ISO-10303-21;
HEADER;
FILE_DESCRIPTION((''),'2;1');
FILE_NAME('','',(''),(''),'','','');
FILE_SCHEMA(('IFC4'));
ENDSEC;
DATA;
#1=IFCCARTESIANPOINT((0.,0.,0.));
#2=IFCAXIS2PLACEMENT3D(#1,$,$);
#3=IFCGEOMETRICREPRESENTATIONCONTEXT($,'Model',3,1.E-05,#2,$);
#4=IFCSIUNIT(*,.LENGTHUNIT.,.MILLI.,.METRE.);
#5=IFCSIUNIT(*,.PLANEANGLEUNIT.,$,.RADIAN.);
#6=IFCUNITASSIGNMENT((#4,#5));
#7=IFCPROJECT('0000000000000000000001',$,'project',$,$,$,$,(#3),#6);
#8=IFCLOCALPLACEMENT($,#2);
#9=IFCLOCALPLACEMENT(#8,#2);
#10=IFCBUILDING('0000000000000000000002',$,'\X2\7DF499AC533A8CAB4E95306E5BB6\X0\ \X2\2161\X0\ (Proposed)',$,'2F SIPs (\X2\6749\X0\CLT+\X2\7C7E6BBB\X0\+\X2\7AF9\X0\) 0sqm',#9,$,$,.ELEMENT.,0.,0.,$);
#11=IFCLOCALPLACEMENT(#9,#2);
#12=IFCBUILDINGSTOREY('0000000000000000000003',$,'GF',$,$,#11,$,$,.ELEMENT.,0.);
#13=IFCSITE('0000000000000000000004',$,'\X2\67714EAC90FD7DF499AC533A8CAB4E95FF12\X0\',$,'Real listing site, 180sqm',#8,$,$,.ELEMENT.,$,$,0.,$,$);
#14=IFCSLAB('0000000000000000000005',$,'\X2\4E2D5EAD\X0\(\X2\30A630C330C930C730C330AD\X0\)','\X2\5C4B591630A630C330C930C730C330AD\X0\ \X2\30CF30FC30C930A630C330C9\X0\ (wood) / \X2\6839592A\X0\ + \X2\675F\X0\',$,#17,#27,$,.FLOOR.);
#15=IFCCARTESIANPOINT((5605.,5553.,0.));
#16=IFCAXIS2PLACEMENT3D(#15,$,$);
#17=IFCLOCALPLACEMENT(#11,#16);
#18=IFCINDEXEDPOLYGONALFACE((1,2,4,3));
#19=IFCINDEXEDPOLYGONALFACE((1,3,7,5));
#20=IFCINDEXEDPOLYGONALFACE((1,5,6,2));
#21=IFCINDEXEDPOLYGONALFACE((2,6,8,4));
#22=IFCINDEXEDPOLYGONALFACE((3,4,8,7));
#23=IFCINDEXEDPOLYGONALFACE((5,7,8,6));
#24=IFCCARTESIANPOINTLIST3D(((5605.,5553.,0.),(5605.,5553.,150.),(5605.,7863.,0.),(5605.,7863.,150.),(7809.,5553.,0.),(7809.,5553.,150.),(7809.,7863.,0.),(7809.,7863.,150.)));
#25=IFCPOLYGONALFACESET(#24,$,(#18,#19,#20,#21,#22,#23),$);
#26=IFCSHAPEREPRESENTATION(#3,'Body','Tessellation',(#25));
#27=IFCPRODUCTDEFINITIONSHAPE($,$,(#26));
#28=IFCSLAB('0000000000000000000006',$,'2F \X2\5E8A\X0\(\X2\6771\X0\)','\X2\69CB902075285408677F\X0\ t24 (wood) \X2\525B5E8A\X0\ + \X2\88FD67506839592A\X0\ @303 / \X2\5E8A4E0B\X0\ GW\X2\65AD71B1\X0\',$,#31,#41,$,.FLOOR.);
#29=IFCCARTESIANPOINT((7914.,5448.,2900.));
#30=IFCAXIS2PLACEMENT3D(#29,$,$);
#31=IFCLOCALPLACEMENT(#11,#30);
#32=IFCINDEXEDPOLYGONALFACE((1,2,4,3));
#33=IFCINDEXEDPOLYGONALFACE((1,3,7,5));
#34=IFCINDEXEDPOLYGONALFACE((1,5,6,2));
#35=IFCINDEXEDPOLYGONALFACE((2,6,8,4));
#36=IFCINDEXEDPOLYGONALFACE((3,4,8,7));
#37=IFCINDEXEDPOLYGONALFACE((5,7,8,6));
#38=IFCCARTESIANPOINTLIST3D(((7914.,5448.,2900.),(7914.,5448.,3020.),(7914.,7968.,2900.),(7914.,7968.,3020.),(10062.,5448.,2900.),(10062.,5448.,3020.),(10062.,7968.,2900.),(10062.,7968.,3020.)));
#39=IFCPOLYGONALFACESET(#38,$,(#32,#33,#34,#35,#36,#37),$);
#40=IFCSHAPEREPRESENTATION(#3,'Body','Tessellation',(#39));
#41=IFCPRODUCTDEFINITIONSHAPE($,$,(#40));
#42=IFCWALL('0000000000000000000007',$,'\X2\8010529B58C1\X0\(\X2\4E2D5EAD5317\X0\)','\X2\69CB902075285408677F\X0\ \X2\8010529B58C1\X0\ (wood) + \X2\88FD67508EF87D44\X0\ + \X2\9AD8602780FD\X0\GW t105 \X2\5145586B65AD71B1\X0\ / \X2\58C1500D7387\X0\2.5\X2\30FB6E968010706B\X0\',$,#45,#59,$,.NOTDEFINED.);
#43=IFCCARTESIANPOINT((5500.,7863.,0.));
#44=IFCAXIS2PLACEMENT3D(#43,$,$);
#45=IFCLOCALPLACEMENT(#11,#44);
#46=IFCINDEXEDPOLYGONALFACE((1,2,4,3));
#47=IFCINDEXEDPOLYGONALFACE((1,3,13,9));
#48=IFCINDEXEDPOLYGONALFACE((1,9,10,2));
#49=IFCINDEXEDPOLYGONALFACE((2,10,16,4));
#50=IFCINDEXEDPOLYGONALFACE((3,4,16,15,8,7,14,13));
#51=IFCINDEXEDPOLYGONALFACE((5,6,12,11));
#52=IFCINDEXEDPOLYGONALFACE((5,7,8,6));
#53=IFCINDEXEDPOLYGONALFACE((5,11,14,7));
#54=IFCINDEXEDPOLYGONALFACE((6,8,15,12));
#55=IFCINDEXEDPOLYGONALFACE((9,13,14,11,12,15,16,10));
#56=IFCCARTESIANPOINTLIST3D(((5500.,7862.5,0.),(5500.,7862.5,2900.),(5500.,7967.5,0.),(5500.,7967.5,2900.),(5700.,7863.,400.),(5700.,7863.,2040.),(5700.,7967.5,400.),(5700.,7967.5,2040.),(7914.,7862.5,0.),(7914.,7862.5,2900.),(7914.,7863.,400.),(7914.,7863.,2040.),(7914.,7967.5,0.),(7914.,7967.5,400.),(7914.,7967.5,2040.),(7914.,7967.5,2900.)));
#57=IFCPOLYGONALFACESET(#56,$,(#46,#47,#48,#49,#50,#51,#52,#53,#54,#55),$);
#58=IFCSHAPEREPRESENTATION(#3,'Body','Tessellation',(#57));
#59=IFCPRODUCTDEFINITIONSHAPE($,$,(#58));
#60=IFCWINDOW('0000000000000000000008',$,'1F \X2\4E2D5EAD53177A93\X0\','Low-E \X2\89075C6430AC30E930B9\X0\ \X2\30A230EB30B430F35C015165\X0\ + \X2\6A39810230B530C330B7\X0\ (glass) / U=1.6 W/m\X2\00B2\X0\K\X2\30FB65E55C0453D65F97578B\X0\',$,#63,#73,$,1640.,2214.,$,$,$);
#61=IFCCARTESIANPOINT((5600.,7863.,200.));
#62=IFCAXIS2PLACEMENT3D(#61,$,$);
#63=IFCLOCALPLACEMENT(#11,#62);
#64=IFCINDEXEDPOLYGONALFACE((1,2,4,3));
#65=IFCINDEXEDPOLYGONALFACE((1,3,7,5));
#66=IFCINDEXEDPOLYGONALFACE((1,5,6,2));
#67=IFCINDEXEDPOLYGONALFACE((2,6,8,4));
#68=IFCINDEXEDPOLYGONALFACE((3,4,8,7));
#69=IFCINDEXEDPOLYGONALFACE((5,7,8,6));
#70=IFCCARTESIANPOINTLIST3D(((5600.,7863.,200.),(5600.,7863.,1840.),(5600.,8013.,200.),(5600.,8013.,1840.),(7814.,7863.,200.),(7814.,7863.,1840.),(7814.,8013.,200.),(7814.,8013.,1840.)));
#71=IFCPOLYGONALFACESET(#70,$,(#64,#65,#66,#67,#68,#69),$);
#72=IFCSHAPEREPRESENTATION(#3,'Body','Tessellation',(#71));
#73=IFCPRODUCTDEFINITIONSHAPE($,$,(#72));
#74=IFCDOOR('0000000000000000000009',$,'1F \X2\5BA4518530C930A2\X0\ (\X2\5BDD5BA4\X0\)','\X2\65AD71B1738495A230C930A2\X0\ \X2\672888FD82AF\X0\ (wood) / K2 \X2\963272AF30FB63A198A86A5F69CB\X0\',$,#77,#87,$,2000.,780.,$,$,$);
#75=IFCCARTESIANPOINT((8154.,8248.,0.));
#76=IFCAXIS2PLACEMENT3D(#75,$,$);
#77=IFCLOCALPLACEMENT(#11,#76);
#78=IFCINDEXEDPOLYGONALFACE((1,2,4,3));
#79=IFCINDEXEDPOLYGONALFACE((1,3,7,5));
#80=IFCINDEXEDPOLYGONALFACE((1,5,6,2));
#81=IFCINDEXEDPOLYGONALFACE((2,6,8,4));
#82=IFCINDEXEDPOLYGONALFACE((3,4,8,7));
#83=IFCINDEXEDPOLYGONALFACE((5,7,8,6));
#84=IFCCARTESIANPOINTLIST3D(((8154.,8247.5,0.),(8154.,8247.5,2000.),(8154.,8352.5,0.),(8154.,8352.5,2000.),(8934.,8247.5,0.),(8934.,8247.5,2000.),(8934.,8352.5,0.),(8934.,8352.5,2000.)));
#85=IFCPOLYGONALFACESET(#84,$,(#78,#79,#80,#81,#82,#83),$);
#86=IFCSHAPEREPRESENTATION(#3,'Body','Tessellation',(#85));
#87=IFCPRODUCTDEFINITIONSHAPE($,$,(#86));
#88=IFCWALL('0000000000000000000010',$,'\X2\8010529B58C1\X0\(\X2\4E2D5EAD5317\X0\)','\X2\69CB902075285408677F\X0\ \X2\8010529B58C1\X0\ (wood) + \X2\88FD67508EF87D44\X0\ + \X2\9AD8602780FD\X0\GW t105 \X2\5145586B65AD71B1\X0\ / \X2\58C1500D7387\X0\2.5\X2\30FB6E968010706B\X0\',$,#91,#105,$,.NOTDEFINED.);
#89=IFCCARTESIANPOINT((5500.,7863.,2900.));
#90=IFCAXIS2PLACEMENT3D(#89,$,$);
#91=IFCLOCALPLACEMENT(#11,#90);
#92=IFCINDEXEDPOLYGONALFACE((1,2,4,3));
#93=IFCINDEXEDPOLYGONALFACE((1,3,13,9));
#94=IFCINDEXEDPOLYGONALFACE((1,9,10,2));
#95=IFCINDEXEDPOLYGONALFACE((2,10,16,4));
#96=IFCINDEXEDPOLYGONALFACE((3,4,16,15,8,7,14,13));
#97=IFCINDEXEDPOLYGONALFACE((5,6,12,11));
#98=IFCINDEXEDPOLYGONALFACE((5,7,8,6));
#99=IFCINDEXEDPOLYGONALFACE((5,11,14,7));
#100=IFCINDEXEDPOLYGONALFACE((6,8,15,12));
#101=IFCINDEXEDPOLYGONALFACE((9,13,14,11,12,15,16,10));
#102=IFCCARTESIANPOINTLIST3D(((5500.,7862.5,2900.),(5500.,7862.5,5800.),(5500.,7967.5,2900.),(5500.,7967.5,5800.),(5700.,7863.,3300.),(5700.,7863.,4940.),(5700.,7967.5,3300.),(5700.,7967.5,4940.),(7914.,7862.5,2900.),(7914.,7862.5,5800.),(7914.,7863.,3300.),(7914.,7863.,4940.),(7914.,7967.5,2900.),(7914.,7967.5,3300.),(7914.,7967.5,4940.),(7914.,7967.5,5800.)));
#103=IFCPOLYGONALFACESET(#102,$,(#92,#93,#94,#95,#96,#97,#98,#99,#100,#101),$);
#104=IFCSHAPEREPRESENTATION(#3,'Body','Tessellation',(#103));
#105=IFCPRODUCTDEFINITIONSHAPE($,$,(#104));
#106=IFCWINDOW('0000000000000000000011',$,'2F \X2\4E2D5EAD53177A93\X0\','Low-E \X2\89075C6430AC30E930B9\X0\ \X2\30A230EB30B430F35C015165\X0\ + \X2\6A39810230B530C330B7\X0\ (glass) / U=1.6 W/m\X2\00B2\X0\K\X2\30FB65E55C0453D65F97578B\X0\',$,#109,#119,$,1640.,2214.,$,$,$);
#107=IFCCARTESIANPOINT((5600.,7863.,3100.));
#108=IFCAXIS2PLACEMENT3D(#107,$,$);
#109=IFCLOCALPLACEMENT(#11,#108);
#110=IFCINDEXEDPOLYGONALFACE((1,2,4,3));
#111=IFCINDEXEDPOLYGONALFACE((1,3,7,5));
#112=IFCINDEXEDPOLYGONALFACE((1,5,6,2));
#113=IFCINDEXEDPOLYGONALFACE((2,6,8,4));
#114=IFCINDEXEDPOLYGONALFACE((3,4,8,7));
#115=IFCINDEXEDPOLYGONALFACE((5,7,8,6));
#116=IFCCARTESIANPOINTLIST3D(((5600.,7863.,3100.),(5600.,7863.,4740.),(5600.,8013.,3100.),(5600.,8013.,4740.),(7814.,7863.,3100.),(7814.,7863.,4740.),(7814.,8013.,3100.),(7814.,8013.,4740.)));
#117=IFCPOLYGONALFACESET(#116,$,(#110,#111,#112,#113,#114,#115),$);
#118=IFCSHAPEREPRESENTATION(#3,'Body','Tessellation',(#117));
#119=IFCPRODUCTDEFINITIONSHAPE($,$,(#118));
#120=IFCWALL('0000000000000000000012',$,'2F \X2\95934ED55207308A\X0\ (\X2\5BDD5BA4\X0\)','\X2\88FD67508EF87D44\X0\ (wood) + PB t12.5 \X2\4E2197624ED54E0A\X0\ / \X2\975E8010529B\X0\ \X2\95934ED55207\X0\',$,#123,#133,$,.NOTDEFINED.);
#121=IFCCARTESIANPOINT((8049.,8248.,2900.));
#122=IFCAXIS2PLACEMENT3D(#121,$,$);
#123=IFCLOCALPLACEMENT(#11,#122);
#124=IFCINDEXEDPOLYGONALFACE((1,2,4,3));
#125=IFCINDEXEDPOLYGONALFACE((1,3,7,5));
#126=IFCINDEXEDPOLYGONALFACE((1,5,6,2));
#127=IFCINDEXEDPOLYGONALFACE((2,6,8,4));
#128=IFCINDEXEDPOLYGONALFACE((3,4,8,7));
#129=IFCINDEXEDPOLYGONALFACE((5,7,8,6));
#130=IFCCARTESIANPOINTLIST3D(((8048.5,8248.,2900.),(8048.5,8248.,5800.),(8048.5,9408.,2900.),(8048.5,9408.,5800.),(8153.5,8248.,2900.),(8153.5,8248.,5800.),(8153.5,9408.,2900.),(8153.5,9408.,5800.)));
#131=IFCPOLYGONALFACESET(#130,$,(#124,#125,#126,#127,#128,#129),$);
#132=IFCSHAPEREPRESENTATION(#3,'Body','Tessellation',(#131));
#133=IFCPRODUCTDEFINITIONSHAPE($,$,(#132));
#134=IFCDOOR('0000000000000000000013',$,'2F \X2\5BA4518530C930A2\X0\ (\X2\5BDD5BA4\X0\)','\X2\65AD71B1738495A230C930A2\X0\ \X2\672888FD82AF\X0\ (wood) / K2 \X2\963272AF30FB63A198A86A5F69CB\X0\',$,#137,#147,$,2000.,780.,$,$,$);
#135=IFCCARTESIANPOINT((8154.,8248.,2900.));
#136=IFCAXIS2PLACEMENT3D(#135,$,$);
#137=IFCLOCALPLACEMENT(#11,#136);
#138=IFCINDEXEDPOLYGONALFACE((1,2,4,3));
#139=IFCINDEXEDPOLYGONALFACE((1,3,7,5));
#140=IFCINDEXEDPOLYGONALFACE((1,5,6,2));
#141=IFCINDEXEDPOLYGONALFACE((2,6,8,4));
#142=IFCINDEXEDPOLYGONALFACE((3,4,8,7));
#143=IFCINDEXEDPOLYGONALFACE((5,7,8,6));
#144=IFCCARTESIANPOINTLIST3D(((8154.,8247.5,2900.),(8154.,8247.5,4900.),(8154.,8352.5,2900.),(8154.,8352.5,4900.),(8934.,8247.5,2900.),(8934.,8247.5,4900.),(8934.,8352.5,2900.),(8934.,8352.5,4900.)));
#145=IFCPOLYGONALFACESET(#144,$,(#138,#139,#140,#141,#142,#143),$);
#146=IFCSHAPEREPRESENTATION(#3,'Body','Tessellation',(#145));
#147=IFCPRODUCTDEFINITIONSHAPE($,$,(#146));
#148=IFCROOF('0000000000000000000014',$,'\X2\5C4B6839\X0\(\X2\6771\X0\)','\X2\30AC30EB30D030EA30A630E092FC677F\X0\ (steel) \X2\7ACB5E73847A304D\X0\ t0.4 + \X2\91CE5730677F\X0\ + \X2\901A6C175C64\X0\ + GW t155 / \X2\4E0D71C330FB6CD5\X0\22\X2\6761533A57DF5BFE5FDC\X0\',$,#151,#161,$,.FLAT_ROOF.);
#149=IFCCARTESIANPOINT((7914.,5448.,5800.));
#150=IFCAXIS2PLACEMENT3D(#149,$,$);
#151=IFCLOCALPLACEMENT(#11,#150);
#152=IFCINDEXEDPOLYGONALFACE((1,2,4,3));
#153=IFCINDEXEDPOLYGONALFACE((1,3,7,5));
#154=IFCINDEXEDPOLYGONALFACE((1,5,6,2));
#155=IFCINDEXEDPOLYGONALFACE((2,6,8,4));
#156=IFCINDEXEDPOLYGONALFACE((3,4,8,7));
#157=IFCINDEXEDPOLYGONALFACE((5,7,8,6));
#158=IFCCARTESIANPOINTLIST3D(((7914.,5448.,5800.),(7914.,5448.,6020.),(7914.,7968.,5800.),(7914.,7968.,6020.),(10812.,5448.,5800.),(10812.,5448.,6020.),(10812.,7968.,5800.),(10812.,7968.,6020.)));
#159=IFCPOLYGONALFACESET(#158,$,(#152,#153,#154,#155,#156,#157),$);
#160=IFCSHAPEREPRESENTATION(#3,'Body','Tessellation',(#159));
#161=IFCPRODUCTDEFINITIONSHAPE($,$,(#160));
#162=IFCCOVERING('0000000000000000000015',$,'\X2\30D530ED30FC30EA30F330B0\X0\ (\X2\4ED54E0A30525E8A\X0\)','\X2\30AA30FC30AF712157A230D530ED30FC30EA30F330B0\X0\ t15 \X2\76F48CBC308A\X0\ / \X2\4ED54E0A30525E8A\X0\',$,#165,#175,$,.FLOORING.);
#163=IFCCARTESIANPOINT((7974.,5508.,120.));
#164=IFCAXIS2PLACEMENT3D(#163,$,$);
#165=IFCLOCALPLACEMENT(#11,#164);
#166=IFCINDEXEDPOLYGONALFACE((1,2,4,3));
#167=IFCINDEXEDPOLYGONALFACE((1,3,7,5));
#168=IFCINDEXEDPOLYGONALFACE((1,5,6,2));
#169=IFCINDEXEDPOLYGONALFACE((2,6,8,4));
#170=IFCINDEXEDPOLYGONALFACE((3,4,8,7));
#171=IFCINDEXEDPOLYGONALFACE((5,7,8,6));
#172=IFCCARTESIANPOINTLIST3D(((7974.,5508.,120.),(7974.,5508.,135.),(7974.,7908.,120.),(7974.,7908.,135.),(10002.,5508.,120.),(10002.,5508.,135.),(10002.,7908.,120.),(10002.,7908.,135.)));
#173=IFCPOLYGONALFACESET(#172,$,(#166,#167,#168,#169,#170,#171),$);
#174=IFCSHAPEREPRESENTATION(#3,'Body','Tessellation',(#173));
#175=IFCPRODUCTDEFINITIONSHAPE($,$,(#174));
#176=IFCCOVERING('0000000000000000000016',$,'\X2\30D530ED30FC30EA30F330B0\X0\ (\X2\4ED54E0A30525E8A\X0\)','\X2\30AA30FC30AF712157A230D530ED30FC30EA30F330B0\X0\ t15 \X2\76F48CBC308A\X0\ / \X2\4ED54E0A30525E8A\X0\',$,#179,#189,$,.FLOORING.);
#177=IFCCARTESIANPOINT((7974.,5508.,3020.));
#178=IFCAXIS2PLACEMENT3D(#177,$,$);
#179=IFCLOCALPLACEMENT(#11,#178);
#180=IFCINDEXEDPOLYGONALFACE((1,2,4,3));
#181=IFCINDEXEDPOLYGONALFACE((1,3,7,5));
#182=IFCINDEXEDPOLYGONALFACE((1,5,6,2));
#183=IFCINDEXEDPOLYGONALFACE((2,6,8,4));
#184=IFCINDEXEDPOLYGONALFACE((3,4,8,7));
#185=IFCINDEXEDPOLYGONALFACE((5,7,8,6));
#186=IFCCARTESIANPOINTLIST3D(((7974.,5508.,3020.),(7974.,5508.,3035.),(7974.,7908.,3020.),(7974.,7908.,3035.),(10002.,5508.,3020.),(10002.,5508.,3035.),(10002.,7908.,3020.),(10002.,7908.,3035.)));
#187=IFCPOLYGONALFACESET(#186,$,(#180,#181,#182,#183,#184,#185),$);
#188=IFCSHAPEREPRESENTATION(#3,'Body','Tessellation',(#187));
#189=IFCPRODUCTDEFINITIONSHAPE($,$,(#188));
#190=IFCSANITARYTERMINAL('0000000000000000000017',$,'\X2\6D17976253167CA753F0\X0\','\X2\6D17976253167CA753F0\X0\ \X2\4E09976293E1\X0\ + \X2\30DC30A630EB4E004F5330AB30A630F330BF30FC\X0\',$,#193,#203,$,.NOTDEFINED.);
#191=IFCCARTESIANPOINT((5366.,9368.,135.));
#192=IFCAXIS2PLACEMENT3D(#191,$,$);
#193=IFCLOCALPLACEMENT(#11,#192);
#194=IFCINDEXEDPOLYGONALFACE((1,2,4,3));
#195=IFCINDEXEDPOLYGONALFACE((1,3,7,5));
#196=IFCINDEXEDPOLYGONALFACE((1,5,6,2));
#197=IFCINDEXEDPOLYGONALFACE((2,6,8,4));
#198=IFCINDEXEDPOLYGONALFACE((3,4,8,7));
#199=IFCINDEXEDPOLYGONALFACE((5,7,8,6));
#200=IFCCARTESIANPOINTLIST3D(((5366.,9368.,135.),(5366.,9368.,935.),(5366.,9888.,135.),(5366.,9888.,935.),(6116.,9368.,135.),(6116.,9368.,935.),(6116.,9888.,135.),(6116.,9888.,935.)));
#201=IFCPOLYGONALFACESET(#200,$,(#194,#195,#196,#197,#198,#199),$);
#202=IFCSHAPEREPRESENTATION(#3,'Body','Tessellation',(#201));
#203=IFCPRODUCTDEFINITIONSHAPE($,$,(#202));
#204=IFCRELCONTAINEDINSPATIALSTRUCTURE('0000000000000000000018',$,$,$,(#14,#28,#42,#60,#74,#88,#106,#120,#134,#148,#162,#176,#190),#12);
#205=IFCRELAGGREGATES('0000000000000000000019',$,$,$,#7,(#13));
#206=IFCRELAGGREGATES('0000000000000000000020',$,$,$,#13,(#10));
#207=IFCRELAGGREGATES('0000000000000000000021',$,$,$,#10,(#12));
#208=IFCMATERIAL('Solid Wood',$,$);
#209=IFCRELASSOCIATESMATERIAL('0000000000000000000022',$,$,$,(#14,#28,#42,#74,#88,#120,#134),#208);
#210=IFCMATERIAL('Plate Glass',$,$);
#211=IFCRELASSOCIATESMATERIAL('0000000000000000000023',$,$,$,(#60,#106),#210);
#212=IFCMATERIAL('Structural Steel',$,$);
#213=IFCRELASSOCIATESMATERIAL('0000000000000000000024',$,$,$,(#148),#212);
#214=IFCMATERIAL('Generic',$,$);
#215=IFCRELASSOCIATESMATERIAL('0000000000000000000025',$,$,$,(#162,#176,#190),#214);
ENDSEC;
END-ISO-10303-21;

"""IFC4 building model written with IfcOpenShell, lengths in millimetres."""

from ifc_helpers import new_model, si_unit, frame, frame_2d, origin, place, context, project, spatial, rectangle, extrude, material, element, fill, save


model = new_model("IFC4")

# Units and contexts
model_context = context("Model", 3, precision=1e-05, world=origin())
ifc_project = project(units=[si_unit("LENGTHUNIT", "METRE", prefix="MILLI"), si_unit("PLANEANGLEUNIT", "RADIAN")], contexts=[model_context])

# Site, building, storey
site_placement = place(None, origin())
site = spatial("IfcSite", under=ifc_project, at=site_placement, Name="東京都練馬区貫井２", ObjectType="Real listing site, 180sqm", CompositionType="ELEMENT", RefElevation=0.0)
building_placement = place(site_placement, origin())
building = spatial("IfcBuilding", under=site, at=building_placement, Name="練馬区貫井の家 Ⅱ (Proposed)", ObjectType="2F SIPs (杉CLT+籾殻+竹) 0sqm", CompositionType="ELEMENT", ElevationOfRefHeight=0.0, ElevationOfTerrain=0.0)
storey_placement = place(building_placement, origin())
storey = spatial("IfcBuildingStorey", under=building, at=storey_placement, Name="GF", CompositionType="ELEMENT", Elevation=0.0)

# Slabs
ifc_material_1 = material(Name="Solid Wood")
slab_1_placement = place(storey_placement, frame((5605.0, 5553.0, 0.0)))
element("IfcSlab", 1, at=slab_1_placement, inside=storey, material=ifc_material_1, Name="中庭(ウッドデッキ)", Description="屋外ウッドデッキ ハードウッド (wood) / 根太 + 束", PredefinedType="FLOOR", context=model_context, shape_type="SweptSolid", body=[
    extrude(rectangle(XDim=2204.0, YDim=2310.0, at=frame_2d((1102.0, 1155.0))), frame((5605.0, 5553.0, 0.0)), (0.0, 0.0, 1.0), 150.0),
])
slab_2_placement = place(storey_placement, frame((7914.0, 5448.0, 2900.0)))
element("IfcSlab", 2, at=slab_2_placement, inside=storey, material=ifc_material_1, Name="2F 床(東)", Description="構造用合板 t24 (wood) 剛床 + 製材根太 @303 / 床下 GW断熱", PredefinedType="FLOOR", context=model_context, shape_type="SweptSolid", body=[
    extrude(rectangle(XDim=2148.0, YDim=2520.0, at=frame_2d((1074.0, 1260.0))), frame((7914.0, 5448.0, 2900.0)), (0.0, 0.0, 1.0), 120.0),
])

# Wall, opening, window
wall_1_placement = place(storey_placement, frame((5500.0, 7863.0, 0.0)))
wall_1 = element("IfcWall", 3, at=wall_1_placement, inside=storey, material=ifc_material_1, Name="耐力壁(中庭北)", Description="構造用合板 耐力壁 (wood) + 製材軸組 + 高性能GW t105 充填断熱 / 壁倍率2.5・準耐火", PredefinedType="NOTDEFINED", context=model_context, shape_type="SweptSolid", body=[
    extrude(rectangle(XDim=2414.0, YDim=105.0, at=frame_2d((1207.0, 52.0))), frame((5500.0, 7863.0, 0.0)), (0.0, 0.0, 1.0), 2900.0),
])
opening_1_placement = place(storey_placement, frame((5600.0, 7863.0, 200.0)))
opening_1 = element("IfcOpeningElement", 4, at=opening_1_placement, cuts=wall_1, PredefinedType="NOTDEFINED", context=model_context, shape_type="SweptSolid", body=[
    extrude(rectangle(XDim=2214.0, YDim=150.0, at=frame_2d((1107.0, 75.0))), frame((5600.0, 7863.0, 200.0)), (0.0, 0.0, 1.0), 1640.0),
])
ifc_material_2 = material(Name="Plate Glass")
window_1_placement = place(storey_placement, frame((5600.0, 7863.0, 200.0)))
window_1 = element("IfcWindow", 5, at=window_1_placement, inside=storey, material=ifc_material_2, Name="1F 中庭北窓", Description="Low-E 複層ガラス アルゴン封入 + 樹脂サッシ (glass) / U=1.6 W/m²K・日射取得型", OverallHeight=1640.0, OverallWidth=2214.0, context=model_context, shape_type="SweptSolid", body=[
    extrude(rectangle(XDim=2214.0, YDim=150.0, at=frame_2d((1107.0, 75.0))), frame((5600.0, 7863.0, 200.0)), (0.0, 0.0, 1.0), 1640.0),
])
fill(opening_1, window_1)

# Door
door_1_placement = place(storey_placement, frame((8154.0, 8248.0, 0.0)))
element("IfcDoor", 6, at=door_1_placement, inside=storey, material=ifc_material_1, Name="1F 室内ドア (寝室)", Description="断熱玄関ドア 木製芯 (wood) / K2 防犯・採風機構", OverallHeight=2000.0, OverallWidth=780.0, context=model_context, shape_type="SweptSolid", body=[
    extrude(rectangle(XDim=780.0, YDim=105.0, at=frame_2d((390.0, 52.0))), frame((8154.0, 8248.0, 0.0)), (0.0, 0.0, 1.0), 2000.0),
])

# Wall, opening, window
wall_2_placement = place(storey_placement, frame((5500.0, 7863.0, 2900.0)))
wall_2 = element("IfcWall", 7, at=wall_2_placement, inside=storey, material=ifc_material_1, Name="耐力壁(中庭北)", Description="構造用合板 耐力壁 (wood) + 製材軸組 + 高性能GW t105 充填断熱 / 壁倍率2.5・準耐火", PredefinedType="NOTDEFINED", context=model_context, shape_type="SweptSolid", body=[
    extrude(rectangle(XDim=2414.0, YDim=105.0, at=frame_2d((1207.0, 52.0))), frame((5500.0, 7863.0, 2900.0)), (0.0, 0.0, 1.0), 2900.0),
])
opening_2_placement = place(storey_placement, frame((5600.0, 7863.0, 3100.0)))
opening_2 = element("IfcOpeningElement", 8, at=opening_2_placement, cuts=wall_2, PredefinedType="NOTDEFINED", context=model_context, shape_type="SweptSolid", body=[
    extrude(rectangle(XDim=2214.0, YDim=150.0, at=frame_2d((1107.0, 75.0))), frame((5600.0, 7863.0, 3100.0)), (0.0, 0.0, 1.0), 1640.0),
])
window_2_placement = place(storey_placement, frame((5600.0, 7863.0, 3100.0)))
window_2 = element("IfcWindow", 9, at=window_2_placement, inside=storey, material=ifc_material_2, Name="2F 中庭北窓", Description="Low-E 複層ガラス アルゴン封入 + 樹脂サッシ (glass) / U=1.6 W/m²K・日射取得型", OverallHeight=1640.0, OverallWidth=2214.0, context=model_context, shape_type="SweptSolid", body=[
    extrude(rectangle(XDim=2214.0, YDim=150.0, at=frame_2d((1107.0, 75.0))), frame((5600.0, 7863.0, 3100.0)), (0.0, 0.0, 1.0), 1640.0),
])
fill(opening_2, window_2)

# Wall
wall_3_placement = place(storey_placement, frame((8049.0, 8248.0, 2900.0)))
element("IfcWall", 10, at=wall_3_placement, inside=storey, material=ifc_material_1, Name="2F 間仕切り (寝室)", Description="製材軸組 (wood) + PB t12.5 両面仕上 / 非耐力 間仕切", PredefinedType="NOTDEFINED", context=model_context, shape_type="SweptSolid", body=[
    extrude(rectangle(XDim=105.0, YDim=1160.0, at=frame_2d((52.0, 580.0))), frame((8049.0, 8248.0, 2900.0)), (0.0, 0.0, 1.0), 2900.0),
])

# Door
door_2_placement = place(storey_placement, frame((8154.0, 8248.0, 2900.0)))
element("IfcDoor", 11, at=door_2_placement, inside=storey, material=ifc_material_1, Name="2F 室内ドア (寝室)", Description="断熱玄関ドア 木製芯 (wood) / K2 防犯・採風機構", OverallHeight=2000.0, OverallWidth=780.0, context=model_context, shape_type="SweptSolid", body=[
    extrude(rectangle(XDim=780.0, YDim=105.0, at=frame_2d((390.0, 52.0))), frame((8154.0, 8248.0, 2900.0)), (0.0, 0.0, 1.0), 2000.0),
])

# Roof
ifc_material_3 = material(Name="Structural Steel")
for number, where, name in (
    (12, (7914.0, 5448.0, 5800.0), "屋根(東)"),
):
    element("IfcRoof", number, at=place(storey_placement, frame(where)), inside=storey, material=ifc_material_3, Name=name, Description="ガルバリウム鋼板 (steel) 立平葺き t0.4 + 野地板 + 通気層 + GW t155 / 不燃・法22条区域対応", PredefinedType="FLAT_ROOF", context=model_context, shape_type="SweptSolid", body=[
        extrude(rectangle(XDim=2898.0, YDim=2520.0, at=frame_2d((1449.0, 1260.0))), frame((7914.0, 5448.0, 5800.0)), (0.0, 0.0, 1.0), 220.0),
    ])

# Coverings
ifc_material_4 = material(Name="Generic")
covering_1_placement = place(storey_placement, frame((7974.0, 5508.0, 120.0)))
element("IfcCovering", 13, at=covering_1_placement, inside=storey, material=ifc_material_4, Name="フローリング (仕上げ床)", Description="オーク無垢フローリング t15 直貼り / 仕上げ床", PredefinedType="FLOORING", context=model_context, shape_type="SweptSolid", body=[
    extrude(rectangle(XDim=2028.0, YDim=2400.0, at=frame_2d((1014.0, 1200.0))), frame((7974.0, 5508.0, 120.0)), (0.0, 0.0, 1.0), 15.0),
])
covering_2_placement = place(storey_placement, frame((7974.0, 5508.0, 3020.0)))
element("IfcCovering", 14, at=covering_2_placement, inside=storey, material=ifc_material_4, Name="フローリング (仕上げ床)", Description="オーク無垢フローリング t15 直貼り / 仕上げ床", PredefinedType="FLOORING", context=model_context, shape_type="SweptSolid", body=[
    extrude(rectangle(XDim=2028.0, YDim=2400.0, at=frame_2d((1014.0, 1200.0))), frame((7974.0, 5508.0, 3020.0)), (0.0, 0.0, 1.0), 15.0),
])

# Sanitary terminal
sanitary_terminal_1_placement = place(storey_placement, frame((5366.0, 9368.0, 135.0)))
element("IfcSanitaryTerminal", 15, at=sanitary_terminal_1_placement, inside=storey, material=ifc_material_4, Name="洗面化粧台", Description="洗面化粧台 三面鏡 + ボウル一体カウンター", PredefinedType="NOTDEFINED", context=model_context, shape_type="SweptSolid", body=[
    extrude(rectangle(XDim=750.0, YDim=520.0, at=frame_2d((375.0, 260.0))), frame((5366.0, 9368.0, 135.0)), (0.0, 0.0, 1.0), 800.0),
])

save(model, "model.ifc")
